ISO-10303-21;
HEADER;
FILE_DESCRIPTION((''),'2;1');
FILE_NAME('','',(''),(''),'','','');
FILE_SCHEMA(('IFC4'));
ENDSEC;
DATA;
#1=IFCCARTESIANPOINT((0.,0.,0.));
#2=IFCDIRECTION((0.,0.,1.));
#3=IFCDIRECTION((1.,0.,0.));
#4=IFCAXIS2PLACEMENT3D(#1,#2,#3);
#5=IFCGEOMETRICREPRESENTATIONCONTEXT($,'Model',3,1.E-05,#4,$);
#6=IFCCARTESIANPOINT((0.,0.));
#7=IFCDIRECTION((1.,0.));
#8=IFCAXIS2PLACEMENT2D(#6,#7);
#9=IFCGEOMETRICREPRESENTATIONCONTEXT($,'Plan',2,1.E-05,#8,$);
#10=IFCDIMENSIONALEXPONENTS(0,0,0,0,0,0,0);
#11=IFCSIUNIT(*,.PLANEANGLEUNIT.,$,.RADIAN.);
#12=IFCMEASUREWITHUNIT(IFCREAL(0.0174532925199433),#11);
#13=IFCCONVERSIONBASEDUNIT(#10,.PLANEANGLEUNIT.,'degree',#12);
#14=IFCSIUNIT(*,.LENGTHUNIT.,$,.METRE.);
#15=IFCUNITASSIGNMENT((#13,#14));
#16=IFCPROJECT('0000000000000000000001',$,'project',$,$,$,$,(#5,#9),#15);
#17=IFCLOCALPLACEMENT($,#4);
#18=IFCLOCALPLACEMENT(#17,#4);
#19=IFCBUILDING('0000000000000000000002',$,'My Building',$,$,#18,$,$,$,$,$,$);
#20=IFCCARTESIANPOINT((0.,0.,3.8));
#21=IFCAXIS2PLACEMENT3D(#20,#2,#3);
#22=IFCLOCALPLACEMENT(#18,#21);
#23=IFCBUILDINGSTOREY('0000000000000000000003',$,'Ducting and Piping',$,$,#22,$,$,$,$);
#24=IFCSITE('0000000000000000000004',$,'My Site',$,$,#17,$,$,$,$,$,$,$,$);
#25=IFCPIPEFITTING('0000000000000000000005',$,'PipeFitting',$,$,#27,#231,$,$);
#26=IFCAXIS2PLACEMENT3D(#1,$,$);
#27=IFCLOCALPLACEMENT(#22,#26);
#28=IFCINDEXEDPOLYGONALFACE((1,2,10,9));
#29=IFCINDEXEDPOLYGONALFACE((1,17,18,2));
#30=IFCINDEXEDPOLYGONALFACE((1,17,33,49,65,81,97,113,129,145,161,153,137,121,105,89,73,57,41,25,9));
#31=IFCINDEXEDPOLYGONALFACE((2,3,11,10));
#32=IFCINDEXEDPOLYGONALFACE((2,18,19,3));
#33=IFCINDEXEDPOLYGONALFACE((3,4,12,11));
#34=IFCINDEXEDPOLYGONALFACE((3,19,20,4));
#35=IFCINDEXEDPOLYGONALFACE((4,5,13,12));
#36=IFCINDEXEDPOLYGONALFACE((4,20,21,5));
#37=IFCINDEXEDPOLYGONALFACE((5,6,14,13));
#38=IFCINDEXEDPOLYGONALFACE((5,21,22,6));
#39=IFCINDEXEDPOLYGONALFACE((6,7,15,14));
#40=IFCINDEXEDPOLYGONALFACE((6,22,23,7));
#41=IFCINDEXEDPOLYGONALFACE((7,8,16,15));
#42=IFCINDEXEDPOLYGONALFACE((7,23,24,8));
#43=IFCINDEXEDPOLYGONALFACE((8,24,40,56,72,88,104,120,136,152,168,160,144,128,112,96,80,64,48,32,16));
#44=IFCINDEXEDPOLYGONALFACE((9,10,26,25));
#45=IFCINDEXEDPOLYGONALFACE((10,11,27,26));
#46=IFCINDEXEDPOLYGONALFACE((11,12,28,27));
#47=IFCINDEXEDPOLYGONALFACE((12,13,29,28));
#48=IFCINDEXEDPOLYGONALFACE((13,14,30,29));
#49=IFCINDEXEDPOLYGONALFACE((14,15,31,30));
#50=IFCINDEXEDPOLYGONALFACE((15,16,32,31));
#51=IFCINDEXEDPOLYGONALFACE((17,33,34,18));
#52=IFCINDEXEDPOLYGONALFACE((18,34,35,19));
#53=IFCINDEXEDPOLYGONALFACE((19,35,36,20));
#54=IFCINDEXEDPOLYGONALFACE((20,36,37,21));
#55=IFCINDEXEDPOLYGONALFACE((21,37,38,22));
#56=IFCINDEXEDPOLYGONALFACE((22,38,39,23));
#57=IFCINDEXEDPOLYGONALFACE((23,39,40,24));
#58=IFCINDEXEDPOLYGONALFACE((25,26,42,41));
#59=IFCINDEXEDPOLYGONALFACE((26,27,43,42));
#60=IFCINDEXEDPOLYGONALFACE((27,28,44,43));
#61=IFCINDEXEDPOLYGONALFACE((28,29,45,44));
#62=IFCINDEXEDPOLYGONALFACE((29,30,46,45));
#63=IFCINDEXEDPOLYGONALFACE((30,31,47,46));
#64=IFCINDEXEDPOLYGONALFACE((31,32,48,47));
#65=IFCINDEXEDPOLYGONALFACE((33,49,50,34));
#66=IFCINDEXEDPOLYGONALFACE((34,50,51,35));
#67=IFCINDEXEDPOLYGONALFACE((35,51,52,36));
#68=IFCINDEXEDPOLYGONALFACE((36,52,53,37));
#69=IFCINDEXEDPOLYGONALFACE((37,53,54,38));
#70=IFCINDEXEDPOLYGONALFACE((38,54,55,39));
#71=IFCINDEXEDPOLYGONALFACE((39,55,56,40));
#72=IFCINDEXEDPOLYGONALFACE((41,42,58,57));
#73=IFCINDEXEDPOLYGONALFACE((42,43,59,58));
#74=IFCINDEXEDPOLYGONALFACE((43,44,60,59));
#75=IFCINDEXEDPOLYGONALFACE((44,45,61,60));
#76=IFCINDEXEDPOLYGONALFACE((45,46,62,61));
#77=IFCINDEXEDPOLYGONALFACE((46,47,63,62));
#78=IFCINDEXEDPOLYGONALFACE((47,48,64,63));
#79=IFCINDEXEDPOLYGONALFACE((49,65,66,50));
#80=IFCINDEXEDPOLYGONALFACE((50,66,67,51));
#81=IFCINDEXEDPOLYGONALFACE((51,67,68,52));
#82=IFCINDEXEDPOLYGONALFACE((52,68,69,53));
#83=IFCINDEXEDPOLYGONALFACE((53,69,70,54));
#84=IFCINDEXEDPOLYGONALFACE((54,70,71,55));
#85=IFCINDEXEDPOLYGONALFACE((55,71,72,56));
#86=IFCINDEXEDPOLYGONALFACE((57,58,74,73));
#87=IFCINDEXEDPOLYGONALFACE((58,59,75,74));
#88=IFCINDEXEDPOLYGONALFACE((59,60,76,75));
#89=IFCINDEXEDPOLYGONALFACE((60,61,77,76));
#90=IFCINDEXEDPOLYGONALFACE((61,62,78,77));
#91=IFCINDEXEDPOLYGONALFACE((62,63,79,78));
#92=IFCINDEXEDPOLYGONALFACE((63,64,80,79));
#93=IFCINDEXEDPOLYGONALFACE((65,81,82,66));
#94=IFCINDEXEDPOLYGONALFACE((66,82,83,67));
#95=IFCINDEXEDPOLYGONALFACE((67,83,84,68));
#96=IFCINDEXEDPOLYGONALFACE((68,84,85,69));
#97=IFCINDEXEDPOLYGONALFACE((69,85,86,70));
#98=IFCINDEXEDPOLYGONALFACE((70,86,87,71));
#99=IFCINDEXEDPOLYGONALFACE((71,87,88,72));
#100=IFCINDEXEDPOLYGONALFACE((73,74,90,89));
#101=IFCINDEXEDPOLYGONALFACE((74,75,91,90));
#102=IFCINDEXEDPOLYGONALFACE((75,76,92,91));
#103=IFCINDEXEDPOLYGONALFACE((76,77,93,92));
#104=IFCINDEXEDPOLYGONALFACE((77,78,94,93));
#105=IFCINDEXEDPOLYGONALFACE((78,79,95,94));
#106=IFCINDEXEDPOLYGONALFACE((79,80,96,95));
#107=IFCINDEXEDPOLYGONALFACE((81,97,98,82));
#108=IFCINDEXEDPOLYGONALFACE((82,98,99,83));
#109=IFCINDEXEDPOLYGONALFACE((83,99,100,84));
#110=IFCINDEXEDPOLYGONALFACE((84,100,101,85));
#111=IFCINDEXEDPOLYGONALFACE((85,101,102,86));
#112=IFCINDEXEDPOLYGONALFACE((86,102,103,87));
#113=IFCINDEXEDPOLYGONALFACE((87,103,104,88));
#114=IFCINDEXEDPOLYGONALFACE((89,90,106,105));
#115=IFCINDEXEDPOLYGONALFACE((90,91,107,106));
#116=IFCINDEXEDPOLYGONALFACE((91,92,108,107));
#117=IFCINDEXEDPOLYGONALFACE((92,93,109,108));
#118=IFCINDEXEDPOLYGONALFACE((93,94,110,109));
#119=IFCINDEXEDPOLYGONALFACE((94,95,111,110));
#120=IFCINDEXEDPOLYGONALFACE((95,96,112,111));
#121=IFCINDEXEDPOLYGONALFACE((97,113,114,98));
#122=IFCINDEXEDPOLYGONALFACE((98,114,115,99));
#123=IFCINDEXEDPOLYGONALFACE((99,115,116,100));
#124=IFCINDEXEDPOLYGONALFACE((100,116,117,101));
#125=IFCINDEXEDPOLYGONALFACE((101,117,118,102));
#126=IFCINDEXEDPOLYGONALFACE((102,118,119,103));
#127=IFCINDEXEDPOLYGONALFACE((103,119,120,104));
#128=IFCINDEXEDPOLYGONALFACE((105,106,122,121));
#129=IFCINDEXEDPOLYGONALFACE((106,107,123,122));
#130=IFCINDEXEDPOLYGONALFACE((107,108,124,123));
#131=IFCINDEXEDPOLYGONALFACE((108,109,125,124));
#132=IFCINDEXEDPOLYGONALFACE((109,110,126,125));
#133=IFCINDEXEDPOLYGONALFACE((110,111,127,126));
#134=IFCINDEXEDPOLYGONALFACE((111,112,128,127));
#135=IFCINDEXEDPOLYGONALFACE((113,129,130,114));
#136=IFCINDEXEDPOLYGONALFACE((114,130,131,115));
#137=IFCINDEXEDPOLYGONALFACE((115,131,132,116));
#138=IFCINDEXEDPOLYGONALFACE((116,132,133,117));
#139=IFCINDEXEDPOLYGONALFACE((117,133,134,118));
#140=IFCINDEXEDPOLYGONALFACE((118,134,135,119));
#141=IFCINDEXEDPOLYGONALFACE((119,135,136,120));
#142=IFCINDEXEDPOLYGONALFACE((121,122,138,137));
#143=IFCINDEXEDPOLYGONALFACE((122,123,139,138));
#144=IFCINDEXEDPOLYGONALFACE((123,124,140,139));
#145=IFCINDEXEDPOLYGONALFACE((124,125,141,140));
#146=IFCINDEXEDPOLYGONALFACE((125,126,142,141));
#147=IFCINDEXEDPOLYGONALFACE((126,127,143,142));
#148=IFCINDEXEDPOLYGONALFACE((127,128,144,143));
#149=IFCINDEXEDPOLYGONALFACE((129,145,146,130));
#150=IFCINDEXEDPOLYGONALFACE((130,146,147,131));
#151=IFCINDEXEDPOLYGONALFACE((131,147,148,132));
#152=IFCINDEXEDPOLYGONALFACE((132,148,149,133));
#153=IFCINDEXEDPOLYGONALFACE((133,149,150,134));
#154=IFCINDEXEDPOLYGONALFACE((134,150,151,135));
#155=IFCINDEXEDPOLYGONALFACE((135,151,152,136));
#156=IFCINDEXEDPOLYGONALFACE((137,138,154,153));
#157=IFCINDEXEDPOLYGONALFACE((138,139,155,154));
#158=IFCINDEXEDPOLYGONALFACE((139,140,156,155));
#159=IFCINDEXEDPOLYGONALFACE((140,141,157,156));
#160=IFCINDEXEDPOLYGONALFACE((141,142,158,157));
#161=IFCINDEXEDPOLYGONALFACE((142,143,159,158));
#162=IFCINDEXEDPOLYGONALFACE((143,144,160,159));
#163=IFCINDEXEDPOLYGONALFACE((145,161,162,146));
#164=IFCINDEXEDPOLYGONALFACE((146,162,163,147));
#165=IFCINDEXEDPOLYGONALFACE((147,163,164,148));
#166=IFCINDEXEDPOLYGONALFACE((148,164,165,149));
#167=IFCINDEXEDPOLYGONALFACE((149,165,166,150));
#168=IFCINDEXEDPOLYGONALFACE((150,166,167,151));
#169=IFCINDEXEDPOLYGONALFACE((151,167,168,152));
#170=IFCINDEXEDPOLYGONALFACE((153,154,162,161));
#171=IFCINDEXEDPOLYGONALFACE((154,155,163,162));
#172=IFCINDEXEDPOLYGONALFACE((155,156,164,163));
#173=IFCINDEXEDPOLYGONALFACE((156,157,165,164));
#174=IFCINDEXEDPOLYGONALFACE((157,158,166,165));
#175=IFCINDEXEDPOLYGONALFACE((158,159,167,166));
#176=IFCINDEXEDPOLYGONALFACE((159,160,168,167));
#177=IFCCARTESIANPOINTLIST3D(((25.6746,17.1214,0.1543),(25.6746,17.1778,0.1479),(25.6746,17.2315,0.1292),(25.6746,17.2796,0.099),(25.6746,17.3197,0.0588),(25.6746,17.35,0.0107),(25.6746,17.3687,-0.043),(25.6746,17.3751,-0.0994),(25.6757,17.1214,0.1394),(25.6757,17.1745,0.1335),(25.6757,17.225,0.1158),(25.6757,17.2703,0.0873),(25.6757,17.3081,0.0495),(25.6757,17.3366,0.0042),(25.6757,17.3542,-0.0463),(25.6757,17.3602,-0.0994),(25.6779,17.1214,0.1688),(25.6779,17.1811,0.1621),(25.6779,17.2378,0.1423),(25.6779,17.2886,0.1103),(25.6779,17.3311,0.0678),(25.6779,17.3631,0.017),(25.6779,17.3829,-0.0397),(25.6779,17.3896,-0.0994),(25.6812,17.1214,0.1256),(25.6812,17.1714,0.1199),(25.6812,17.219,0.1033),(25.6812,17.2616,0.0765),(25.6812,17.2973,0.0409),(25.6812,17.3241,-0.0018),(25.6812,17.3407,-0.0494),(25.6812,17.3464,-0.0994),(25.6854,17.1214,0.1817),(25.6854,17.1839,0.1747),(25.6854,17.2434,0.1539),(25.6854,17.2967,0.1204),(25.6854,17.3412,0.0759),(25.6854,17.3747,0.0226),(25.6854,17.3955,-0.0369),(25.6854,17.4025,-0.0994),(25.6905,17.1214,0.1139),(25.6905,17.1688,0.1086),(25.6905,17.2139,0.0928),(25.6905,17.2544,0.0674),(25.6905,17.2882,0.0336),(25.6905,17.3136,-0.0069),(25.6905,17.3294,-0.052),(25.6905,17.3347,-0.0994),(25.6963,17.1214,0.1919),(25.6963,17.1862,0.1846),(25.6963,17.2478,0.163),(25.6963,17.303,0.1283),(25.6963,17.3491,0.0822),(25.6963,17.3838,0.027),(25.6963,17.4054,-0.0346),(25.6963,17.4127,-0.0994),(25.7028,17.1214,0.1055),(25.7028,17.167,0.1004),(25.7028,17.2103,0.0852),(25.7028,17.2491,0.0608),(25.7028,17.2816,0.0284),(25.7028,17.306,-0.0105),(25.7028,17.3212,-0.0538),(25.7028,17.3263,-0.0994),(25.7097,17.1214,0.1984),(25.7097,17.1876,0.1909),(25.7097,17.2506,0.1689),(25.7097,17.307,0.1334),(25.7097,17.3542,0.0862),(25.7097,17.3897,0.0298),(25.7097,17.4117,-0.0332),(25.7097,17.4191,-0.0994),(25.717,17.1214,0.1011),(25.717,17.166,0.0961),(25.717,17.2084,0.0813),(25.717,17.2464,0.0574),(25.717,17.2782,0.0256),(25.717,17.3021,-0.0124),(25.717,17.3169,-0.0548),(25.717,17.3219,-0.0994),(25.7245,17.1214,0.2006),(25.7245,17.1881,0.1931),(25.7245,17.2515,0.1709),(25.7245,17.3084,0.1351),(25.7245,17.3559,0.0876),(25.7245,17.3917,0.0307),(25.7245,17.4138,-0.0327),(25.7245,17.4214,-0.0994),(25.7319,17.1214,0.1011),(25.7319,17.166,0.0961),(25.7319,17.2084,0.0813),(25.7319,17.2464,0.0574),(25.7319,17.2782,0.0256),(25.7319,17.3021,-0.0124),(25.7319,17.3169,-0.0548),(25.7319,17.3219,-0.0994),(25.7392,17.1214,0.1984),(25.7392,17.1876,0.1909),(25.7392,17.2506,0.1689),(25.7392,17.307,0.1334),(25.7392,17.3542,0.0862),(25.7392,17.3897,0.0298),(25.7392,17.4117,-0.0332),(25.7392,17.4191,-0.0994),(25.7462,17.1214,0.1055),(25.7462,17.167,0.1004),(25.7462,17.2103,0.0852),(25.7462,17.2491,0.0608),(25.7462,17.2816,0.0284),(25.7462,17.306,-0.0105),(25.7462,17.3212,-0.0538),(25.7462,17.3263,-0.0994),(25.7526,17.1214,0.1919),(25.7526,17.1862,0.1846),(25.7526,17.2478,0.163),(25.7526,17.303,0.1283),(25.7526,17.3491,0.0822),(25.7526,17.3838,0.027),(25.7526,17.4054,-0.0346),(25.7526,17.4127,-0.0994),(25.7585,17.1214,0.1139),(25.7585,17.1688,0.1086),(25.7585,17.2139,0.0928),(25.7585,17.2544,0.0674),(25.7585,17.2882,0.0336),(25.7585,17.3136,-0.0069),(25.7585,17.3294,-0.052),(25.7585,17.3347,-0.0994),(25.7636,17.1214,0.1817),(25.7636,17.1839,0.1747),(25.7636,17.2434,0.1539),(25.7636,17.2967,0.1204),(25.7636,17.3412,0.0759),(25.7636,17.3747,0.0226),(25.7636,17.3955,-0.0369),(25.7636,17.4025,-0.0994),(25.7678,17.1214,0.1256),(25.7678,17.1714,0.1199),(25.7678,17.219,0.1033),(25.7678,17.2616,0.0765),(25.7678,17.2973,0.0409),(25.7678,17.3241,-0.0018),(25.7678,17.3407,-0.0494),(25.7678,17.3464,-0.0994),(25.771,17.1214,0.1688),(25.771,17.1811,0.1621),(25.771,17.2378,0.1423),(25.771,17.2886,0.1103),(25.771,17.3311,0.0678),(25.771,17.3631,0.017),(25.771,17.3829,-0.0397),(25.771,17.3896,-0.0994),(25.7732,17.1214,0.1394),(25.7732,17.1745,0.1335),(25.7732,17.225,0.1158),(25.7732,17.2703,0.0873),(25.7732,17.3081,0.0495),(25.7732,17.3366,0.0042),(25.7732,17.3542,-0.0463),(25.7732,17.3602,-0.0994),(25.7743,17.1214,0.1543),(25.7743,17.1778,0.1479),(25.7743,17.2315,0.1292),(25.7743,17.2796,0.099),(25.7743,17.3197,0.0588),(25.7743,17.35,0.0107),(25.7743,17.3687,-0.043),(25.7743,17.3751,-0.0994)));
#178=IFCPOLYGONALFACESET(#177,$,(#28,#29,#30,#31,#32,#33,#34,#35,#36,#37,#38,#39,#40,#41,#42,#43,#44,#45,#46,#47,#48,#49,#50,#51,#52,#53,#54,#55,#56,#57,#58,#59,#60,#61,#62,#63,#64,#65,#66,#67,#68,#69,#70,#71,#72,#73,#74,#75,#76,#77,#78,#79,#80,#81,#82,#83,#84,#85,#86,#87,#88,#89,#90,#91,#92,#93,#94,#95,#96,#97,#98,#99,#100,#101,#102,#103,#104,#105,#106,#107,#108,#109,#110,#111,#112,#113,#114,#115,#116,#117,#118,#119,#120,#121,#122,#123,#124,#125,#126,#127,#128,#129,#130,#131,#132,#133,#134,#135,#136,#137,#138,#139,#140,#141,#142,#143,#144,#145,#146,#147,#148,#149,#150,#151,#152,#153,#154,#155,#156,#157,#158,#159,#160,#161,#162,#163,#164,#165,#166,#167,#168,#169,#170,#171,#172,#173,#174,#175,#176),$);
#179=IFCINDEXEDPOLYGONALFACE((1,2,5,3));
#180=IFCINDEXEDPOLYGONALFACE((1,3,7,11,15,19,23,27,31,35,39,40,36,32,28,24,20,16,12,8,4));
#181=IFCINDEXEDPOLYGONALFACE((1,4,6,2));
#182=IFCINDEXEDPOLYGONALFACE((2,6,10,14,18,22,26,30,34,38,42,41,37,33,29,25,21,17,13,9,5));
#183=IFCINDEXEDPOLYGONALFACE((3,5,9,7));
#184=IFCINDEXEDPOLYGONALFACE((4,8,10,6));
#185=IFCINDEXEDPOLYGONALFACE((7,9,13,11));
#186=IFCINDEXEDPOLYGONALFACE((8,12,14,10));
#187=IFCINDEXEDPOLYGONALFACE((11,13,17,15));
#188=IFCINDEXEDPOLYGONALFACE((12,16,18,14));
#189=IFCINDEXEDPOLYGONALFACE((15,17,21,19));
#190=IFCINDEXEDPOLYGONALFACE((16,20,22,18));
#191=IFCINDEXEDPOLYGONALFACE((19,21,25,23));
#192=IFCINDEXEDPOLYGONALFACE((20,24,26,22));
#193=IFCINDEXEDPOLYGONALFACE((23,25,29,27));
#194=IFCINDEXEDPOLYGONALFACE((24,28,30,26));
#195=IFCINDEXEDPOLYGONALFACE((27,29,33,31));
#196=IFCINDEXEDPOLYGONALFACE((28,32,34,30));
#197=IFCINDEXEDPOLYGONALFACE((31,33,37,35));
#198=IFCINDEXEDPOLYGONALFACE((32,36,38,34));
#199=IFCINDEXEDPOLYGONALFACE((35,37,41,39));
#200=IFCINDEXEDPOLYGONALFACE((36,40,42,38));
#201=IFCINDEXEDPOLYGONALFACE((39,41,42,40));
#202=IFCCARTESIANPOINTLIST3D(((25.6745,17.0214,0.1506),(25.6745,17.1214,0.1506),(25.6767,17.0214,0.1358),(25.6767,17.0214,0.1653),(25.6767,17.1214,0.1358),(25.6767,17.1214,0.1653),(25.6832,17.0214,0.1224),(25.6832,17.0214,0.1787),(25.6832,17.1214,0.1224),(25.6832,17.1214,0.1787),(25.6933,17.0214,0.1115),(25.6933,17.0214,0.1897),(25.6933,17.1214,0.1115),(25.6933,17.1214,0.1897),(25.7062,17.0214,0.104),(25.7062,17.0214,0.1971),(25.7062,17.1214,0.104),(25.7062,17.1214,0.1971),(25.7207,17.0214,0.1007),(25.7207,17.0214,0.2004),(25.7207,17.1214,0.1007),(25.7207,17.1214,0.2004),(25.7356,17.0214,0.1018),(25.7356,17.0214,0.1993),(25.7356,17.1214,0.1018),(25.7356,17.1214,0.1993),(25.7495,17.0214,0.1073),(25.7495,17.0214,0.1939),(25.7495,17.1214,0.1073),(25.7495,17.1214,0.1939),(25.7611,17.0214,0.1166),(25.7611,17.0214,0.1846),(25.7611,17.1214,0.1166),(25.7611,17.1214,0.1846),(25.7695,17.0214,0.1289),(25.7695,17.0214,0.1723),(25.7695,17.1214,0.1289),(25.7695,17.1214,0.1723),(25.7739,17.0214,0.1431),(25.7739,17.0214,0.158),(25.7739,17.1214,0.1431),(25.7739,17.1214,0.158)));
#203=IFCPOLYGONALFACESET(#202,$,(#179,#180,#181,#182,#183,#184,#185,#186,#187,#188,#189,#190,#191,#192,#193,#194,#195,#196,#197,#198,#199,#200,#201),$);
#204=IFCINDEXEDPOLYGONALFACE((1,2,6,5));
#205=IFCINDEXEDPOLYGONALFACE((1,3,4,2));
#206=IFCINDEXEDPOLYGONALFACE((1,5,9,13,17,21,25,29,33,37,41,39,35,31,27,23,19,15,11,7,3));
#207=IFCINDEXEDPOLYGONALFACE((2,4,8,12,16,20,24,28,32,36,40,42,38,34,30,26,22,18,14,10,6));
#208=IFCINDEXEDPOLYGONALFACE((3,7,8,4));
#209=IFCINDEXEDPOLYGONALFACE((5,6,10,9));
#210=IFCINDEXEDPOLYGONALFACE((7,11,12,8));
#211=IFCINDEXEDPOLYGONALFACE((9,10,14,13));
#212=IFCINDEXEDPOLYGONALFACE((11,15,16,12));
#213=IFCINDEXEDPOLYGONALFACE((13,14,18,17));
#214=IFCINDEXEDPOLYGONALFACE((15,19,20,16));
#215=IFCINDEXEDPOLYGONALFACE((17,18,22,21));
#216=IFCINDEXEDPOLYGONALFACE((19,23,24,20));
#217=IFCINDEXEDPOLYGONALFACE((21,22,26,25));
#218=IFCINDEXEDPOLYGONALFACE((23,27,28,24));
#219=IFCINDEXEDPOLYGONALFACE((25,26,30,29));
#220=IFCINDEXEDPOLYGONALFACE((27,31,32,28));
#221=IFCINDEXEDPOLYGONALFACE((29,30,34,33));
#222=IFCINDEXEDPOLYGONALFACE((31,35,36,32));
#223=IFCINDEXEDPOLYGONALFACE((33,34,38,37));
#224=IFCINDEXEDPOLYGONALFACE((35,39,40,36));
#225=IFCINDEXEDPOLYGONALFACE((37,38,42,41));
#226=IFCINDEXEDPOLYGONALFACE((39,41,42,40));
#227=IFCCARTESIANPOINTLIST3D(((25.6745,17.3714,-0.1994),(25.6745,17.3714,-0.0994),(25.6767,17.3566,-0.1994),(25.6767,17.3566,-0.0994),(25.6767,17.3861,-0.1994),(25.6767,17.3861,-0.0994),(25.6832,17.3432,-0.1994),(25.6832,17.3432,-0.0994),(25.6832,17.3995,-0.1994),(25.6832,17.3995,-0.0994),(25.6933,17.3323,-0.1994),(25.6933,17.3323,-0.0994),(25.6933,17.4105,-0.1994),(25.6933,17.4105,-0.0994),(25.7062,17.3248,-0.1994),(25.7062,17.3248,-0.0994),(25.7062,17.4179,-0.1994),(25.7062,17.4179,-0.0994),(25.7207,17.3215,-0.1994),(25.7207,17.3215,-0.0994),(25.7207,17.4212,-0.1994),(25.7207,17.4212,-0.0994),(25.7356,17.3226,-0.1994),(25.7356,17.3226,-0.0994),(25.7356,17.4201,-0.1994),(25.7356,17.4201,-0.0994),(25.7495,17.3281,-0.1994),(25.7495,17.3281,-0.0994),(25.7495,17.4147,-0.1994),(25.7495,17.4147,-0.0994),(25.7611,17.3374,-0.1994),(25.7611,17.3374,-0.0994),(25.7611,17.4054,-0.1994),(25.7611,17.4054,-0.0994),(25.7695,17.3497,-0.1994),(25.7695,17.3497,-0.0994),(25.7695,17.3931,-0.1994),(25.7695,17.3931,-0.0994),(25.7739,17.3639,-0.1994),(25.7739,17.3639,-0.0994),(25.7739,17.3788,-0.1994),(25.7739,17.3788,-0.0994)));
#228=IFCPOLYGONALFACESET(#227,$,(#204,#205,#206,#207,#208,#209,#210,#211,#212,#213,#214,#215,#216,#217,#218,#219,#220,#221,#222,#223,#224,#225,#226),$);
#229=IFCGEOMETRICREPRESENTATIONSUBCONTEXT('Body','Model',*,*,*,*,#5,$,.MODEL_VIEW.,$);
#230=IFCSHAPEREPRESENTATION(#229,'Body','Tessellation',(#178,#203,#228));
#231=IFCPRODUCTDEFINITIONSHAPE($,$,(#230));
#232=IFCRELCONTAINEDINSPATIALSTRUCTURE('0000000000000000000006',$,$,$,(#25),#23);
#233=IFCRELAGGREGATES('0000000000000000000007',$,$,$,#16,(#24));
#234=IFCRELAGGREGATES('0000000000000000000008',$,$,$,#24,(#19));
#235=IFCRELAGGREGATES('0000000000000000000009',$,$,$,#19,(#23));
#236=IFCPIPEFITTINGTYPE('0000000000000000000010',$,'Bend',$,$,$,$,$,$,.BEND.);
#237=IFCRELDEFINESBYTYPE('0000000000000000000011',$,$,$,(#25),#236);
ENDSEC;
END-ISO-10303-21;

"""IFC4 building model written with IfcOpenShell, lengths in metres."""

from ifc_helpers import new_model, entity, si_unit, converted_unit, frame, origin_with_axes, origin_2d_with_axis, place, context, subcontext, project, spatial, circle, extrude, source, transform, mapped, type_object, type_shapes, element, save


model = new_model("IFC4")

# Units and contexts
model_context = context("Model", 3, precision=1e-05, world=origin_with_axes())
plan_context = context("Plan", 2, precision=1e-05, world=origin_2d_with_axis())
body_context = subcontext(model_context, "Body", "Model", "MODEL_VIEW")
ifc_project = project(units=[converted_unit("PLANEANGLEUNIT", "degree", entity("IfcReal", 0.0174532925199433), si_unit("PLANEANGLEUNIT", "RADIAN"), dimensions=[0, 0, 0, 0, 0, 0, 0]), si_unit("LENGTHUNIT", "METRE")], contexts=[model_context, plan_context])

# Site, building, storey
site_placement = place(None, origin_with_axes())
site = spatial("IfcSite", under=ifc_project, at=site_placement, Name="My Site")
building_placement = place(site_placement, origin_with_axes())
building = spatial("IfcBuilding", under=site, at=building_placement, Name="My Building")
storey_placement = place(building_placement, frame((0.0, 0.0, 3.8), z_axis=(0.0, 0.0, 1.0), x_axis=(1.0, 0.0, 0.0)))
storey = spatial("IfcBuildingStorey", under=building, at=storey_placement, Name="Ducting and Piping")

# Pipe fitting
pipe_fitting_type = type_object("IfcPipeFittingType", Name="Bend", PredefinedType="BEND")
shared_shape = source(origin_with_axes(), body_context, "Body", "SolidModel", [
    entity("IfcSweptDiskSolid", entity("IfcIndexedPolyCurve", entity("IfcCartesianPointList3D", [[0.0, 0.0, 0.1], [0.0, -0.0732, 0.2768], [0.0, -0.25, 0.35]]), [entity("IfcArcIndex", [1, 2, 3])]), 0.05),
    extrude(circle(Radius=0.05), origin_with_axes(), (0.0, 0.0, 1.0), 0.1),
    extrude(circle(Radius=0.05), frame((0.0, -0.25, 0.35), z_axis=(0.0, -1.0, 0.0), x_axis=(1.0, 0.0, 0.0)), (0.0, 0.0, 1.0), 0.1),
])
type_shapes(pipe_fitting_type, [shared_shape])
for number, where, z_axis, x_axis, name in (
    (1, (25.7245, 17.0214, 0.1506), (0.0, 1.0, 0.0), (-1.0, 0.0, 0.0), "PipeFitting"),
):
    element("IfcPipeFitting", number, at=place(storey_placement, frame(where, z_axis=z_axis, x_axis=x_axis)), inside=storey, type_object=pipe_fitting_type, Name=name, context=body_context, shape_type="MappedRepresentation", body=[
        mapped(shared_shape, transform((0.0, 0.0, 0.0), x_axis=(1.0, 0.0, 0.0), y_axis=(0.0, 1.0, 0.0), z_axis=(0.0, 0.0, 1.0), scale=1.0)),
    ])

save(model, "model.ifc")
